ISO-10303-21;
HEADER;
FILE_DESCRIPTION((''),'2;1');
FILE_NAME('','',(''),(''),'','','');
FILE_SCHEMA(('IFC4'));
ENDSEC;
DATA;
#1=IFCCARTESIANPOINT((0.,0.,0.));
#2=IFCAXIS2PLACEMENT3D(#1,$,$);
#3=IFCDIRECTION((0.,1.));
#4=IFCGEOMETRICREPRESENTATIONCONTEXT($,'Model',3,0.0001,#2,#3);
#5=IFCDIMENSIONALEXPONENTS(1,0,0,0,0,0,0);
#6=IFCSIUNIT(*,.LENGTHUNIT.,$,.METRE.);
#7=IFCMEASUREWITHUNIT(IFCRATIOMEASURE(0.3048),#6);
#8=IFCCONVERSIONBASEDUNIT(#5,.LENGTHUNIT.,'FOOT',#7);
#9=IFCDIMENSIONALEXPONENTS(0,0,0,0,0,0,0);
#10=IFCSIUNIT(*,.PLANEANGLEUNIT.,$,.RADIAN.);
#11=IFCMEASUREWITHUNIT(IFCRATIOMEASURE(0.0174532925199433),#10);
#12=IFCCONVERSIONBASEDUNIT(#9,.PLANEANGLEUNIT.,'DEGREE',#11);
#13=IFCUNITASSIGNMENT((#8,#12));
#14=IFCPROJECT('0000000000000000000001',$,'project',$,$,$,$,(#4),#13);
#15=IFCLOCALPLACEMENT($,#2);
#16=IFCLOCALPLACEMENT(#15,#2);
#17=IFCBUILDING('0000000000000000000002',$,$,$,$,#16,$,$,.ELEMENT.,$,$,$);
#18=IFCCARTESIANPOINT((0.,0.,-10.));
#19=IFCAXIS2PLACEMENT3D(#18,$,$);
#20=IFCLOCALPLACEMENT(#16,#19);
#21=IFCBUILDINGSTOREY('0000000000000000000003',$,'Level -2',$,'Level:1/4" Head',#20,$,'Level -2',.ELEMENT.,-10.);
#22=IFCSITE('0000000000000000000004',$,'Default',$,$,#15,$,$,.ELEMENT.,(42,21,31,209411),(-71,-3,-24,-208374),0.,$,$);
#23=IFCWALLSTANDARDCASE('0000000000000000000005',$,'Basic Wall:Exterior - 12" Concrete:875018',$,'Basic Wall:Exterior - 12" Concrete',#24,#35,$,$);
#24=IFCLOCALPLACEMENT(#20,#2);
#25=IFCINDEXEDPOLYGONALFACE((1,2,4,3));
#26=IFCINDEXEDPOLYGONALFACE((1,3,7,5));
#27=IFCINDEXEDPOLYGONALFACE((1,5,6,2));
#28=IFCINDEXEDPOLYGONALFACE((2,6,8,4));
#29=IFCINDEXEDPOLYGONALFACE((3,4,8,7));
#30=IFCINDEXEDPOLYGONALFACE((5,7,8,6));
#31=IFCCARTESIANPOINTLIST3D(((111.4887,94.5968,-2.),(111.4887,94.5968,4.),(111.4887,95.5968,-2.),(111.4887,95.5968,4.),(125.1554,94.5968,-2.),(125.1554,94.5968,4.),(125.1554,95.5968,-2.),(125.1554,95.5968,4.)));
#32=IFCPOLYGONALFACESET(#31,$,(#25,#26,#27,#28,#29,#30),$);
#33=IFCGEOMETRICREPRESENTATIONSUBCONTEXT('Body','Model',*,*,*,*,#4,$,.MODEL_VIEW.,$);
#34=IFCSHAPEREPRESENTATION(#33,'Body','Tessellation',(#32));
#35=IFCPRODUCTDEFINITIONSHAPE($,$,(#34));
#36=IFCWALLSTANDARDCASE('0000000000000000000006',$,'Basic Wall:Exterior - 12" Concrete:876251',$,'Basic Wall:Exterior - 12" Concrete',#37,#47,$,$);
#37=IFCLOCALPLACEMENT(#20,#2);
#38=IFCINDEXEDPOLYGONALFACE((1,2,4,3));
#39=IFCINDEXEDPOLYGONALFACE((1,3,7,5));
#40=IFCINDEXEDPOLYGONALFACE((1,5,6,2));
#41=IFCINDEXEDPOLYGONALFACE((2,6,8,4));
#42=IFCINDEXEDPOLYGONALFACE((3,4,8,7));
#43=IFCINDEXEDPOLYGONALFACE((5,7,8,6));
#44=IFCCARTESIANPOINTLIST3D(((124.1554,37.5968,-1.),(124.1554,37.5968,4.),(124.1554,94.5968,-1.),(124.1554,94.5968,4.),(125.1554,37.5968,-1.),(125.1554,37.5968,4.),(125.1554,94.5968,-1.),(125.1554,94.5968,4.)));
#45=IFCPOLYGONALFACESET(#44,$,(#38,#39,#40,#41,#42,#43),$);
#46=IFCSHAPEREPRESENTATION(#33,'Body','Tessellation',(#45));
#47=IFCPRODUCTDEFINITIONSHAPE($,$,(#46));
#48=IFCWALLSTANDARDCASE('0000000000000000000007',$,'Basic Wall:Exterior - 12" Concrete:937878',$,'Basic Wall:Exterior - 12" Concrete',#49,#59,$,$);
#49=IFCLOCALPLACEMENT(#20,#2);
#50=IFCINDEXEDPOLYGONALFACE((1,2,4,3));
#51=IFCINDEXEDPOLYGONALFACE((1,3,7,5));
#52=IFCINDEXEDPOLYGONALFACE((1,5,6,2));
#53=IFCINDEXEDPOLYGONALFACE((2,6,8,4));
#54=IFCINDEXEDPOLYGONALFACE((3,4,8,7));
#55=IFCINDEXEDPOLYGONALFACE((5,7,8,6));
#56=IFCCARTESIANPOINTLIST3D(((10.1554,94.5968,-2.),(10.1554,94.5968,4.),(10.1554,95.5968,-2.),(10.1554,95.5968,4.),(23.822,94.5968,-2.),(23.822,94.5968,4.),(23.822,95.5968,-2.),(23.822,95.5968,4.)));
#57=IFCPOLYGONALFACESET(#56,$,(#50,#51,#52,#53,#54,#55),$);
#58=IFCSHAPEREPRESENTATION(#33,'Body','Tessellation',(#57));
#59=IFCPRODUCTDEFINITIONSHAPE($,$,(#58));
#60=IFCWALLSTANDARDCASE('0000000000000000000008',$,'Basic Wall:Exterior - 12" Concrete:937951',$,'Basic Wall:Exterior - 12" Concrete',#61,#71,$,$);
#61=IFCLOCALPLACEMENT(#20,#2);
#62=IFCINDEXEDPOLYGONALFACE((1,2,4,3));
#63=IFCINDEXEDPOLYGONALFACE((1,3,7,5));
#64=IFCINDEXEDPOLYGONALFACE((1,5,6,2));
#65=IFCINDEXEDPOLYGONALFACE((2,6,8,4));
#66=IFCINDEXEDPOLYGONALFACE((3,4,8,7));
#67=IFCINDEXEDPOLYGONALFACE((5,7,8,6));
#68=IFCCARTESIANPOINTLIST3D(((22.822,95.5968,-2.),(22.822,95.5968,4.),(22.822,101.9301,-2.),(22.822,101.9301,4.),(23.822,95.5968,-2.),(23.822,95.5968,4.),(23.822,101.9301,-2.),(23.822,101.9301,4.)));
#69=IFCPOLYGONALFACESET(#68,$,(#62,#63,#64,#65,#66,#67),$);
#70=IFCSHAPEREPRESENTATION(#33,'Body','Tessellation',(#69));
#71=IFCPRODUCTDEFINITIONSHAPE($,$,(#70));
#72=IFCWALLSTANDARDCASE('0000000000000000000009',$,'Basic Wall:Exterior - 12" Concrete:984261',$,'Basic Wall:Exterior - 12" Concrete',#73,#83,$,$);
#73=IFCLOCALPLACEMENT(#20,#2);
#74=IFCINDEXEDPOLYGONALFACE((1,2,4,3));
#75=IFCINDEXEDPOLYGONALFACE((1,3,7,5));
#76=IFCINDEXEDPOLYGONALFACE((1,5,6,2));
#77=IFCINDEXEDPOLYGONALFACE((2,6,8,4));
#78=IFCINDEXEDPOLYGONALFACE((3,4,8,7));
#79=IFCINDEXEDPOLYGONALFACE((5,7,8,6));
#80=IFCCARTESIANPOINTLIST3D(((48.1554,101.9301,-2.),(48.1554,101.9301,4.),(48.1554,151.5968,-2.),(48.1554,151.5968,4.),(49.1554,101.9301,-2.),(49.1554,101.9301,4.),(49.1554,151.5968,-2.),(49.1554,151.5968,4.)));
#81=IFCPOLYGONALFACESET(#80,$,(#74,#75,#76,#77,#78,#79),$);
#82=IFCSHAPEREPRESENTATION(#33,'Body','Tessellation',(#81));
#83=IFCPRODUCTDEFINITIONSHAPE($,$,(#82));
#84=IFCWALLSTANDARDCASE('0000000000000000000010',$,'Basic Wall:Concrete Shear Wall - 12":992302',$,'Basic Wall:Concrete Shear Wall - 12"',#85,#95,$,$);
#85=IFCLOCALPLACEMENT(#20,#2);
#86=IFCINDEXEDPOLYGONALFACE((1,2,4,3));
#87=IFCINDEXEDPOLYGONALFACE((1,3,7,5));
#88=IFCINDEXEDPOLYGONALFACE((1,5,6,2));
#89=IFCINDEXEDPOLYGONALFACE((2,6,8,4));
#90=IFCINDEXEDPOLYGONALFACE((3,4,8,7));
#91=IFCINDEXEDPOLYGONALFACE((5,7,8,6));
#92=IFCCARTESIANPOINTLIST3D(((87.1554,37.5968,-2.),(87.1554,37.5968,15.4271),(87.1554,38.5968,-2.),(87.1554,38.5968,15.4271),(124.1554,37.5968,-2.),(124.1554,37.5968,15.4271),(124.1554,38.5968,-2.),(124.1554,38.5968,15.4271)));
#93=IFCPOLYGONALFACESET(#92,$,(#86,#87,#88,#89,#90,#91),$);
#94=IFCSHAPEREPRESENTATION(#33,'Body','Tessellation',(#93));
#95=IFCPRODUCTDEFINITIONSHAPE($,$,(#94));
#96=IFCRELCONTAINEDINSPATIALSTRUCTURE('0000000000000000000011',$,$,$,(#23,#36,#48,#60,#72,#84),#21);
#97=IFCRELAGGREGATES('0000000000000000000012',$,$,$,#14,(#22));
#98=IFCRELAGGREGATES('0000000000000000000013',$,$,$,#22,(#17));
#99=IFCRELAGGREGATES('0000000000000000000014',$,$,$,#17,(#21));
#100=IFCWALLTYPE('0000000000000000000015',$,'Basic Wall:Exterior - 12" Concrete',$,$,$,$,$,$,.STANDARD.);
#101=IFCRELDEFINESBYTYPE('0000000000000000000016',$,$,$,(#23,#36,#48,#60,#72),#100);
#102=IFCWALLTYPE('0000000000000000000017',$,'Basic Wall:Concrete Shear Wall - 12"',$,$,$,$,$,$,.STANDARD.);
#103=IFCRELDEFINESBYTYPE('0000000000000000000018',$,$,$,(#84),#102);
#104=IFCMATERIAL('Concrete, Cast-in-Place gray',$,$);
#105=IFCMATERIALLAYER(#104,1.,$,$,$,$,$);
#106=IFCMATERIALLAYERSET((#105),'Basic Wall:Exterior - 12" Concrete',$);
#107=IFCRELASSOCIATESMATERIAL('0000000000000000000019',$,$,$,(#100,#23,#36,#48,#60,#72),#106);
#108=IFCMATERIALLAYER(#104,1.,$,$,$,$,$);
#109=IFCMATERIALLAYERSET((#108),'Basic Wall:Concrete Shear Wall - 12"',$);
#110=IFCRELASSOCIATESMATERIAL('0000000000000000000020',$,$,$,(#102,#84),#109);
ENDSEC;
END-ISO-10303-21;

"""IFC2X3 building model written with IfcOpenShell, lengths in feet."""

from ifc_helpers import new_model, entity, si_unit, converted_unit, direction, frame, frame_2d, origin, place, context, subcontext, project, spatial, polyline, rectangle, extrude, clip, bounded_halfspace, material, layer, layer_set, layer_usage, type_object, element, save


model = new_model("IFC2X3")

# Units and contexts
model_context = context("Model", 3, precision=0.0001, world=origin(), true_north=direction((0.0, 1.0)))
body_context = subcontext(model_context, "Body", "Model", "MODEL_VIEW")
ifc_project = project(units=[converted_unit("LENGTHUNIT", "FOOT", entity("IfcRatioMeasure", 0.3048), si_unit("LENGTHUNIT", "METRE"), dimensions=[1, 0, 0, 0, 0, 0, 0]), converted_unit("PLANEANGLEUNIT", "DEGREE", entity("IfcRatioMeasure", 0.0174532925199433), si_unit("PLANEANGLEUNIT", "RADIAN"), dimensions=[0, 0, 0, 0, 0, 0, 0])], contexts=[model_context])

# Site, building, storey
site_placement = place(None, origin())
site = spatial("IfcSite", under=ifc_project, at=site_placement, Name="Default", CompositionType="ELEMENT", RefLatitude=(42, 21, 31, 209411), RefLongitude=(-71, -3, -24, -208374), RefElevation=0.0)
building_placement = place(site_placement, origin())
building = spatial("IfcBuilding", under=site, at=building_placement, CompositionType="ELEMENT")
storey_placement = place(building_placement, frame((0.0, 0.0, -10.0)))
storey = spatial("IfcBuildingStorey", under=building, at=storey_placement, Name="Level -2", ObjectType="Level:1/4\" Head", LongName="Level -2", CompositionType="ELEMENT", Elevation=-10.0)

# Shared definitions
ifc_material = material(Name="Concrete, Cast-in-Place gray")

# Walls
ifc_layer_1 = layer(ifc_material, 1.0)
ifc_layer_set_1 = layer_set([ifc_layer_1], Name="Basic Wall:Exterior - 12\" Concrete")
wall_type_1 = type_object("IfcWallType", Name="Basic Wall:Exterior - 12\" Concrete", PredefinedType="STANDARD", material=ifc_layer_set_1)
ifc_layer_usage_1 = layer_usage(ifc_layer_set_1, "AXIS2", "NEGATIVE", 0.5)
wall_1_placement = place(storey_placement, frame((125.1554, 95.0968, -2.0), z_axis=(0.0, 0.0, 1.0), x_axis=(-1.0, 0.0, 0.0)))
element("IfcWallStandardCase", 1, at=wall_1_placement, inside=storey, type_object=wall_type_1, material=ifc_layer_usage_1, Name="Basic Wall:Exterior - 12\" Concrete:875018", ObjectType="Basic Wall:Exterior - 12\" Concrete", context=body_context, shape_type="SweptSolid", body=[
    extrude(rectangle(XDim=13.6667, YDim=1.0, at=frame_2d((6.8333, 0.0), x_axis=(-1.0, 0.0))), origin(), (0.0, 0.0, 1.0), 6.0),
])
ifc_layer_usage_2 = layer_usage(ifc_layer_set_1, "AXIS2", "NEGATIVE", 0.5)
wall_2_placement = place(storey_placement, frame((124.6554, 37.5968, -1.0), z_axis=(0.0, 0.0, 1.0), x_axis=(0.0, 1.0, 0.0)))
element("IfcWallStandardCase", 2, at=wall_2_placement, inside=storey, type_object=wall_type_1, material=ifc_layer_usage_2, Name="Basic Wall:Exterior - 12\" Concrete:876251", ObjectType="Basic Wall:Exterior - 12\" Concrete", context=body_context, shape_type="SweptSolid", body=[
    extrude(rectangle(XDim=57.0, YDim=1.0, at=frame_2d((28.5, 0.0), x_axis=(-1.0, 0.0))), origin(), (0.0, 0.0, 1.0), 5.0),
])
ifc_layer_usage_3 = layer_usage(ifc_layer_set_1, "AXIS2", "NEGATIVE", 0.5)
wall_3_placement = place(storey_placement, frame((23.822, 95.0968, -2.0), z_axis=(0.0, 0.0, 1.0), x_axis=(-1.0, 0.0, 0.0)))
element("IfcWallStandardCase", 3, at=wall_3_placement, inside=storey, type_object=wall_type_1, material=ifc_layer_usage_3, Name="Basic Wall:Exterior - 12\" Concrete:937878", ObjectType="Basic Wall:Exterior - 12\" Concrete", context=body_context, shape_type="SweptSolid", body=[
    extrude(rectangle(XDim=13.6667, YDim=1.0, at=frame_2d((6.8333, 0.0), x_axis=(-1.0, 0.0))), origin(), (0.0, 0.0, 1.0), 6.0),
])
ifc_layer_usage_4 = layer_usage(ifc_layer_set_1, "AXIS2", "NEGATIVE", 0.5)
wall_4_placement = place(storey_placement, frame((23.322, 95.5968, -2.0), z_axis=(0.0, 0.0, 1.0), x_axis=(0.0, 1.0, 0.0)))
element("IfcWallStandardCase", 4, at=wall_4_placement, inside=storey, type_object=wall_type_1, material=ifc_layer_usage_4, Name="Basic Wall:Exterior - 12\" Concrete:937951", ObjectType="Basic Wall:Exterior - 12\" Concrete", context=body_context, shape_type="SweptSolid", body=[
    extrude(rectangle(XDim=6.3333, YDim=1.0, at=frame_2d((3.1667, 0.0), x_axis=(-1.0, 0.0))), origin(), (0.0, 0.0, 1.0), 6.0),
])
ifc_layer_usage_5 = layer_usage(ifc_layer_set_1, "AXIS2", "NEGATIVE", 0.5)
wall_5_placement = place(storey_placement, frame((48.6554, 151.5968, -2.0), z_axis=(0.0, 0.0, 1.0), x_axis=(0.0, -1.0, 0.0)))
element("IfcWallStandardCase", 5, at=wall_5_placement, inside=storey, type_object=wall_type_1, material=ifc_layer_usage_5, Name="Basic Wall:Exterior - 12\" Concrete:984261", ObjectType="Basic Wall:Exterior - 12\" Concrete", context=body_context, shape_type="SweptSolid", body=[
    extrude(rectangle(XDim=49.6667, YDim=1.0, at=frame_2d((24.8333, 0.0), x_axis=(-1.0, 0.0))), origin(), (0.0, 0.0, 1.0), 6.0),
])
ifc_layer_2 = layer(ifc_material, 1.0)
ifc_layer_set_2 = layer_set([ifc_layer_2], Name="Basic Wall:Concrete Shear Wall - 12\"")
wall_type_2 = type_object("IfcWallType", Name="Basic Wall:Concrete Shear Wall - 12\"", PredefinedType="STANDARD", material=ifc_layer_set_2)
ifc_layer_usage_6 = layer_usage(ifc_layer_set_2, "AXIS2", "NEGATIVE", 0.5)
wall_6_placement = place(storey_placement, frame((124.1554, 38.0968, -2.0), z_axis=(0.0, 0.0, 1.0), x_axis=(-1.0, 0.0, 0.0)))
element("IfcWallStandardCase", 6, at=wall_6_placement, inside=storey, type_object=wall_type_2, material=ifc_layer_usage_6, Name="Basic Wall:Concrete Shear Wall - 12\":992302", ObjectType="Basic Wall:Concrete Shear Wall - 12\"", context=body_context, shape_type="Clipping", body=[
    clip(extrude(rectangle(XDim=37.0, YDim=1.0, at=frame_2d((18.5, 0.0), x_axis=(-1.0, 0.0))), origin(), (0.0, 0.0, 1.0), 17.4271), bounded_halfspace(frame((18.5, -0.5, 17.4271), z_axis=(0.0, 0.0, -1.0), x_axis=(0.0, -1.0, 0.0)), True, frame((18.5, -0.5, 17.4271)), polyline([(0.0, 0.0), (9.5, 0.0), (9.5, 1.0), (0.0, 1.0), (0.0, 0.0)]))),
])

save(model, "model.ifc")
